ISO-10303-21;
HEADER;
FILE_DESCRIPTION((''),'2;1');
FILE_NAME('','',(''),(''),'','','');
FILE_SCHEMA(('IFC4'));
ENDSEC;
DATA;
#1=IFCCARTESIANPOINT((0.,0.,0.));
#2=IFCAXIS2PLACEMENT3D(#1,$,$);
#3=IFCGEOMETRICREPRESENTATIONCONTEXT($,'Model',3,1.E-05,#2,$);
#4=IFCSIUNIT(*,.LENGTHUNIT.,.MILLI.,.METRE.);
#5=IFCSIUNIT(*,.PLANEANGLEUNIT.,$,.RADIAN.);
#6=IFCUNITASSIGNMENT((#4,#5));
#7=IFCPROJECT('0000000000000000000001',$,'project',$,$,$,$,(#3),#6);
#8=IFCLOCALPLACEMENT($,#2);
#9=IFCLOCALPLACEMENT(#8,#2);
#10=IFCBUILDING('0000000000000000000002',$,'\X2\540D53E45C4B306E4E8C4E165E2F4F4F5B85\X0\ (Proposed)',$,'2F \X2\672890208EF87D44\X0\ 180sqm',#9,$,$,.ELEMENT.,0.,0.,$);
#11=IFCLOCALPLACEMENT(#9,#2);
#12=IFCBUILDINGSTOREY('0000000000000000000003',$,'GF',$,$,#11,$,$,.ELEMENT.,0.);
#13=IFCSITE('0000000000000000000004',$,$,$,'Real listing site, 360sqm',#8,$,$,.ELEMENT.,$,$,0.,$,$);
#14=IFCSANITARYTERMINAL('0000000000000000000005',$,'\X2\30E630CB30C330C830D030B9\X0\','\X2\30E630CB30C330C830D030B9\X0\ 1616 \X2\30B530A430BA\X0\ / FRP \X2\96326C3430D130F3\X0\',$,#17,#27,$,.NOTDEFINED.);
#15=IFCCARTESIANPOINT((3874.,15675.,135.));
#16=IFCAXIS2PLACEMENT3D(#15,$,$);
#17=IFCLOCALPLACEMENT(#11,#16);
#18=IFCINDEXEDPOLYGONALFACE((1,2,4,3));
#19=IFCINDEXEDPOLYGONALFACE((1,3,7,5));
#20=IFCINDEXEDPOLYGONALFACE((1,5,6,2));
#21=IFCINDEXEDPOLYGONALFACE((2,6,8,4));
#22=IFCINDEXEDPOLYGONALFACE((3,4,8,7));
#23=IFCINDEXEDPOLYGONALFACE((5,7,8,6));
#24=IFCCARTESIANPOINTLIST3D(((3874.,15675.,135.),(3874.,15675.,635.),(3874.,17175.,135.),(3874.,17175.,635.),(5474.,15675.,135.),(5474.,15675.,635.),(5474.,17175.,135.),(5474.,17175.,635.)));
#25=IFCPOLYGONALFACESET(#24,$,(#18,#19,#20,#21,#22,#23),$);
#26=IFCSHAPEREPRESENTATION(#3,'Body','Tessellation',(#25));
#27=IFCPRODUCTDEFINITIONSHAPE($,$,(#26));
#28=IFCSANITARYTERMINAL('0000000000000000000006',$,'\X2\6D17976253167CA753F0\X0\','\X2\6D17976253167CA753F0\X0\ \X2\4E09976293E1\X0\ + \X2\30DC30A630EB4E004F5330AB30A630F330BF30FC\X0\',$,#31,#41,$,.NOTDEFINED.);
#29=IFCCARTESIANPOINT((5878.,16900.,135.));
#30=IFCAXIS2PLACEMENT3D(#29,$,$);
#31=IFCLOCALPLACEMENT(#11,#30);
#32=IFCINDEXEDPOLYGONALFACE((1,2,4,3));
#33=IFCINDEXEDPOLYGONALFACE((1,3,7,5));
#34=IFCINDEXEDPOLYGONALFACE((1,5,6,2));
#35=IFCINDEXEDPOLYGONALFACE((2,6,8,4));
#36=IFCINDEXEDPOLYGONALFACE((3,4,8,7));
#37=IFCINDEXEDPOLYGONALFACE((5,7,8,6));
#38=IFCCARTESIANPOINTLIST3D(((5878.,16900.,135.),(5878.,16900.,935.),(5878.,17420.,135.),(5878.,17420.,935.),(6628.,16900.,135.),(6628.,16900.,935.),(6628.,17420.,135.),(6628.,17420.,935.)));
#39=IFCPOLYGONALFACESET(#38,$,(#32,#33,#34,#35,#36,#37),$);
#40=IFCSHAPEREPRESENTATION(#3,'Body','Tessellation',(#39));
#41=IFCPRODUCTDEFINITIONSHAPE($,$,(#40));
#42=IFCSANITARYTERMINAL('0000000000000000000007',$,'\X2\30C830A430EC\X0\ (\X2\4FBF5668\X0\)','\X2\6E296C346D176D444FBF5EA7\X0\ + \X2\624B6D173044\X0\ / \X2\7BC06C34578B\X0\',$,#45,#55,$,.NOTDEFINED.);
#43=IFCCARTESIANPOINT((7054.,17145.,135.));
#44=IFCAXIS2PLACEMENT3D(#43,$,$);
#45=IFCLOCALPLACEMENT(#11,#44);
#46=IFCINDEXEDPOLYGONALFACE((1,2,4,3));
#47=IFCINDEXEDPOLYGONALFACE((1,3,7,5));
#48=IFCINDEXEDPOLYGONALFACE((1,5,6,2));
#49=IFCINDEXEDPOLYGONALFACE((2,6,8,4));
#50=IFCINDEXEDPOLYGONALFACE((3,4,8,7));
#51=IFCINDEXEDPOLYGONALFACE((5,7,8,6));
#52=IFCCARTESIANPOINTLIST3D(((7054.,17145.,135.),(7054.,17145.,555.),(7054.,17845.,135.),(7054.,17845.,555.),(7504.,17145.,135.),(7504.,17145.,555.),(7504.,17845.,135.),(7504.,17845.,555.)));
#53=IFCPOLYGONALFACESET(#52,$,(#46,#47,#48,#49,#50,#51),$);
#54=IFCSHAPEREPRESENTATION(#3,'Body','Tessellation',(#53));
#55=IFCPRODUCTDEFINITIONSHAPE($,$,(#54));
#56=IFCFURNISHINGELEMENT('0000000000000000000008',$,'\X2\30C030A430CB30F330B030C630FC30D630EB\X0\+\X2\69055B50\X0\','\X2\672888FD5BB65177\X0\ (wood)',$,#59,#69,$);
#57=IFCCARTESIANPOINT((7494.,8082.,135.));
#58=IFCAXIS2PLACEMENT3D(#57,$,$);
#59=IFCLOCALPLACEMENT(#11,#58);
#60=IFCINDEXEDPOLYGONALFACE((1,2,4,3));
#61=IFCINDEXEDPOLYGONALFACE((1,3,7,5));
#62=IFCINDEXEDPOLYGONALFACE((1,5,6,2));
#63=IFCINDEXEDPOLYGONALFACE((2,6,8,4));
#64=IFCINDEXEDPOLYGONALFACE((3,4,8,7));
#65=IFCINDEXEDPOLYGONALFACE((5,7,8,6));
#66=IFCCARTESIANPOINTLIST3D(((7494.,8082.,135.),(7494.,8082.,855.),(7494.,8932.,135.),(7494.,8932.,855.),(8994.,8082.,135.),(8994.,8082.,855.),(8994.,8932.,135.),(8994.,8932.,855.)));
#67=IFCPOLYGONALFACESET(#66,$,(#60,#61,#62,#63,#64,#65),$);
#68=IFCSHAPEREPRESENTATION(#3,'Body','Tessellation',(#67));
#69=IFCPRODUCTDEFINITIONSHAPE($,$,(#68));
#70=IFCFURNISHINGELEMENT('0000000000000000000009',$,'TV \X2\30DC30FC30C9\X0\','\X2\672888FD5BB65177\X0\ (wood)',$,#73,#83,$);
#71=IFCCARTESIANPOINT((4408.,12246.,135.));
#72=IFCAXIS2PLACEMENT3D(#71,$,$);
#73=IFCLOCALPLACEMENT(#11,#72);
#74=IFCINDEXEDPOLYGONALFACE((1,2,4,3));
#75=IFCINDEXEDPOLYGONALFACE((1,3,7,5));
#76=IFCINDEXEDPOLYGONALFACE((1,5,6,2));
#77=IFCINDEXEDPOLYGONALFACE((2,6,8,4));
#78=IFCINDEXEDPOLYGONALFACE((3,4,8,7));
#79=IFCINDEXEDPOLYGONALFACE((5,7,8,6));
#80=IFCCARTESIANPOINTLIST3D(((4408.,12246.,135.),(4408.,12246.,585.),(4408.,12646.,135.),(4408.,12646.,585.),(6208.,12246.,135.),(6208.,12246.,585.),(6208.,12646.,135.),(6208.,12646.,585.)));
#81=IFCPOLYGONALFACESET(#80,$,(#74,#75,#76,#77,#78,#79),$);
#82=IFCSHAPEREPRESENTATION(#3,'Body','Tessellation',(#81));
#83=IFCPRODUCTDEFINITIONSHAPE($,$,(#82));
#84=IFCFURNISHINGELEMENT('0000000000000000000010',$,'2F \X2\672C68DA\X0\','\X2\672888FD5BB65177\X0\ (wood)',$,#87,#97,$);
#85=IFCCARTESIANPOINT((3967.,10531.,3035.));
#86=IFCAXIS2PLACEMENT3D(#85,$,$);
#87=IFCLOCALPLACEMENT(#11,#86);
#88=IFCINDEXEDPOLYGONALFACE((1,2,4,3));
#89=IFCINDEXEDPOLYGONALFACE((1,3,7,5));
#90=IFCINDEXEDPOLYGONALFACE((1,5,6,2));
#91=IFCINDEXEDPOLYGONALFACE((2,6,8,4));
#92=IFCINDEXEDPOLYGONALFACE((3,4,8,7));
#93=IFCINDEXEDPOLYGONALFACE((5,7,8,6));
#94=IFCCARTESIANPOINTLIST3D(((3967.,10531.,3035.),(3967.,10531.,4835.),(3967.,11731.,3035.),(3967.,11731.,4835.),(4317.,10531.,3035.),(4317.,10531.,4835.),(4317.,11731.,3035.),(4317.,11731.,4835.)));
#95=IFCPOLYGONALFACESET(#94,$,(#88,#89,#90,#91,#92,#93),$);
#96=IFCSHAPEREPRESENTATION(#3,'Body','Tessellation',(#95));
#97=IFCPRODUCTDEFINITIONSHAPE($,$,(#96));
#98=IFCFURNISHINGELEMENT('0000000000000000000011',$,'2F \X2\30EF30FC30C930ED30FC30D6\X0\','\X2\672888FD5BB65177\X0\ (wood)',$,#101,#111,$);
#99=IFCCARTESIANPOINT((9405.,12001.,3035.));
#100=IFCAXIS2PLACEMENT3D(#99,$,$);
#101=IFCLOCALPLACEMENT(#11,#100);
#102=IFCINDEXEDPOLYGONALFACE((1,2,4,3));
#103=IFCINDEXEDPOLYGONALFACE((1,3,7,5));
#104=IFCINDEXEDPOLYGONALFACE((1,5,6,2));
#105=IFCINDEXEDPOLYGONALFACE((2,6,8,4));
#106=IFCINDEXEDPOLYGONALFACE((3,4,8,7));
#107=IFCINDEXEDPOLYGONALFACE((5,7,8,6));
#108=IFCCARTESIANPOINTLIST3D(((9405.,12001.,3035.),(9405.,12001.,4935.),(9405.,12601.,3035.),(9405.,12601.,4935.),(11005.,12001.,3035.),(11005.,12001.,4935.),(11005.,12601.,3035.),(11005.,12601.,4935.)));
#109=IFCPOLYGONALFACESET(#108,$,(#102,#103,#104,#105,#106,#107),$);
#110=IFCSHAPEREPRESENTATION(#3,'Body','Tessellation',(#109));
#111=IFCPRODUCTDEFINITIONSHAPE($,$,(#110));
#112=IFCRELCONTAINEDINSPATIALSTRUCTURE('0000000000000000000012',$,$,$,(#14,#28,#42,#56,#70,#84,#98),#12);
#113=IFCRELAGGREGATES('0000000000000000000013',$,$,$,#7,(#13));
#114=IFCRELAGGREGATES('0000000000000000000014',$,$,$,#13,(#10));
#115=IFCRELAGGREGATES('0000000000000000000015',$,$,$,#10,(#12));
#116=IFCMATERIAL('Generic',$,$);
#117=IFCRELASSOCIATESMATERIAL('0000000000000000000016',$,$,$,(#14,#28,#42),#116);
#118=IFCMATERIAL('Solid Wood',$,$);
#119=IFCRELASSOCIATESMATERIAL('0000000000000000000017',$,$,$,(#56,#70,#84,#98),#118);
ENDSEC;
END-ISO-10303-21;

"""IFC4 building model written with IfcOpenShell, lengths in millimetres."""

from ifc_helpers import new_model, si_unit, frame, frame_2d, origin, place, context, project, spatial, rectangle, extrude, material, element, save


model = new_model("IFC4")

# Units and contexts
model_context = context("Model", 3, precision=1e-05, world=origin())
ifc_project = project(units=[si_unit("LENGTHUNIT", "METRE", prefix="MILLI"), si_unit("PLANEANGLEUNIT", "RADIAN")], contexts=[model_context])

# Site, building, storey
site_placement = place(None, origin())
site = spatial("IfcSite", under=ifc_project, at=site_placement, ObjectType="Real listing site, 360sqm", CompositionType="ELEMENT", RefElevation=0.0)
building_placement = place(site_placement, origin())
building = spatial("IfcBuilding", under=site, at=building_placement, Name="名古屋の二世帯住宅 (Proposed)", ObjectType="2F 木造軸組 180sqm", CompositionType="ELEMENT", ElevationOfRefHeight=0.0, ElevationOfTerrain=0.0)
storey_placement = place(building_placement, origin())
storey = spatial("IfcBuildingStorey", under=building, at=storey_placement, Name="GF", CompositionType="ELEMENT", Elevation=0.0)

# Shared definitions
ifc_material_1 = material(Name="Solid Wood")

# Shared definitions
ifc_material_2 = material(Name="Generic")

# Sanitary terminals
sanitary_terminal_1_placement = place(storey_placement, frame((3874.0, 15675.0, 135.0)))
element("IfcSanitaryTerminal", 1, at=sanitary_terminal_1_placement, inside=storey, material=ifc_material_2, Name="ユニットバス", Description="ユニットバス 1616 サイズ / FRP 防水パン", PredefinedType="NOTDEFINED", context=model_context, shape_type="SweptSolid", body=[
    extrude(rectangle(XDim=1600.0, YDim=1500.0, at=frame_2d((800.0, 750.0))), frame((3874.0, 15675.0, 135.0)), (0.0, 0.0, 1.0), 500.0),
])
sanitary_terminal_2_placement = place(storey_placement, frame((5878.0, 16900.0, 135.0)))
element("IfcSanitaryTerminal", 2, at=sanitary_terminal_2_placement, inside=storey, material=ifc_material_2, Name="洗面化粧台", Description="洗面化粧台 三面鏡 + ボウル一体カウンター", PredefinedType="NOTDEFINED", context=model_context, shape_type="SweptSolid", body=[
    extrude(rectangle(XDim=750.0, YDim=520.0, at=frame_2d((375.0, 260.0))), frame((5878.0, 16900.0, 135.0)), (0.0, 0.0, 1.0), 800.0),
])
sanitary_terminal_3_placement = place(storey_placement, frame((7054.0, 17145.0, 135.0)))
element("IfcSanitaryTerminal", 3, at=sanitary_terminal_3_placement, inside=storey, material=ifc_material_2, Name="トイレ (便器)", Description="温水洗浄便座 + 手洗い / 節水型", PredefinedType="NOTDEFINED", context=model_context, shape_type="SweptSolid", body=[
    extrude(rectangle(XDim=450.0, YDim=700.0, at=frame_2d((225.0, 350.0))), frame((7054.0, 17145.0, 135.0)), (0.0, 0.0, 1.0), 420.0),
])

# Furnishing elements
furnishing_1_placement = place(storey_placement, frame((7494.0, 8082.0, 135.0)))
element("IfcFurnishingElement", 4, at=furnishing_1_placement, inside=storey, material=ifc_material_1, Name="ダイニングテーブル+椅子", Description="木製家具 (wood)", context=model_context, shape_type="SweptSolid", body=[
    extrude(rectangle(XDim=1500.0, YDim=850.0, at=frame_2d((750.0, 425.0))), frame((7494.0, 8082.0, 135.0)), (0.0, 0.0, 1.0), 720.0),
])
furnishing_2_placement = place(storey_placement, frame((4408.0, 12246.0, 135.0)))
element("IfcFurnishingElement", 5, at=furnishing_2_placement, inside=storey, material=ifc_material_1, Name="TV ボード", Description="木製家具 (wood)", context=model_context, shape_type="SweptSolid", body=[
    extrude(rectangle(XDim=1800.0, YDim=400.0, at=frame_2d((900.0, 200.0))), frame((4408.0, 12246.0, 135.0)), (0.0, 0.0, 1.0), 450.0),
])
furnishing_3_placement = place(storey_placement, frame((3967.0, 10531.0, 3035.0)))
element("IfcFurnishingElement", 6, at=furnishing_3_placement, inside=storey, material=ifc_material_1, Name="2F 本棚", Description="木製家具 (wood)", context=model_context, shape_type="SweptSolid", body=[
    extrude(rectangle(XDim=350.0, YDim=1200.0, at=frame_2d((175.0, 600.0))), frame((3967.0, 10531.0, 3035.0)), (0.0, 0.0, 1.0), 1800.0),
])
furnishing_4_placement = place(storey_placement, frame((9405.0, 12001.0, 3035.0)))
element("IfcFurnishingElement", 7, at=furnishing_4_placement, inside=storey, material=ifc_material_1, Name="2F ワードローブ", Description="木製家具 (wood)", context=model_context, shape_type="SweptSolid", body=[
    extrude(rectangle(XDim=1600.0, YDim=600.0, at=frame_2d((800.0, 300.0))), frame((9405.0, 12001.0, 3035.0)), (0.0, 0.0, 1.0), 1900.0),
])

save(model, "model.ifc")
